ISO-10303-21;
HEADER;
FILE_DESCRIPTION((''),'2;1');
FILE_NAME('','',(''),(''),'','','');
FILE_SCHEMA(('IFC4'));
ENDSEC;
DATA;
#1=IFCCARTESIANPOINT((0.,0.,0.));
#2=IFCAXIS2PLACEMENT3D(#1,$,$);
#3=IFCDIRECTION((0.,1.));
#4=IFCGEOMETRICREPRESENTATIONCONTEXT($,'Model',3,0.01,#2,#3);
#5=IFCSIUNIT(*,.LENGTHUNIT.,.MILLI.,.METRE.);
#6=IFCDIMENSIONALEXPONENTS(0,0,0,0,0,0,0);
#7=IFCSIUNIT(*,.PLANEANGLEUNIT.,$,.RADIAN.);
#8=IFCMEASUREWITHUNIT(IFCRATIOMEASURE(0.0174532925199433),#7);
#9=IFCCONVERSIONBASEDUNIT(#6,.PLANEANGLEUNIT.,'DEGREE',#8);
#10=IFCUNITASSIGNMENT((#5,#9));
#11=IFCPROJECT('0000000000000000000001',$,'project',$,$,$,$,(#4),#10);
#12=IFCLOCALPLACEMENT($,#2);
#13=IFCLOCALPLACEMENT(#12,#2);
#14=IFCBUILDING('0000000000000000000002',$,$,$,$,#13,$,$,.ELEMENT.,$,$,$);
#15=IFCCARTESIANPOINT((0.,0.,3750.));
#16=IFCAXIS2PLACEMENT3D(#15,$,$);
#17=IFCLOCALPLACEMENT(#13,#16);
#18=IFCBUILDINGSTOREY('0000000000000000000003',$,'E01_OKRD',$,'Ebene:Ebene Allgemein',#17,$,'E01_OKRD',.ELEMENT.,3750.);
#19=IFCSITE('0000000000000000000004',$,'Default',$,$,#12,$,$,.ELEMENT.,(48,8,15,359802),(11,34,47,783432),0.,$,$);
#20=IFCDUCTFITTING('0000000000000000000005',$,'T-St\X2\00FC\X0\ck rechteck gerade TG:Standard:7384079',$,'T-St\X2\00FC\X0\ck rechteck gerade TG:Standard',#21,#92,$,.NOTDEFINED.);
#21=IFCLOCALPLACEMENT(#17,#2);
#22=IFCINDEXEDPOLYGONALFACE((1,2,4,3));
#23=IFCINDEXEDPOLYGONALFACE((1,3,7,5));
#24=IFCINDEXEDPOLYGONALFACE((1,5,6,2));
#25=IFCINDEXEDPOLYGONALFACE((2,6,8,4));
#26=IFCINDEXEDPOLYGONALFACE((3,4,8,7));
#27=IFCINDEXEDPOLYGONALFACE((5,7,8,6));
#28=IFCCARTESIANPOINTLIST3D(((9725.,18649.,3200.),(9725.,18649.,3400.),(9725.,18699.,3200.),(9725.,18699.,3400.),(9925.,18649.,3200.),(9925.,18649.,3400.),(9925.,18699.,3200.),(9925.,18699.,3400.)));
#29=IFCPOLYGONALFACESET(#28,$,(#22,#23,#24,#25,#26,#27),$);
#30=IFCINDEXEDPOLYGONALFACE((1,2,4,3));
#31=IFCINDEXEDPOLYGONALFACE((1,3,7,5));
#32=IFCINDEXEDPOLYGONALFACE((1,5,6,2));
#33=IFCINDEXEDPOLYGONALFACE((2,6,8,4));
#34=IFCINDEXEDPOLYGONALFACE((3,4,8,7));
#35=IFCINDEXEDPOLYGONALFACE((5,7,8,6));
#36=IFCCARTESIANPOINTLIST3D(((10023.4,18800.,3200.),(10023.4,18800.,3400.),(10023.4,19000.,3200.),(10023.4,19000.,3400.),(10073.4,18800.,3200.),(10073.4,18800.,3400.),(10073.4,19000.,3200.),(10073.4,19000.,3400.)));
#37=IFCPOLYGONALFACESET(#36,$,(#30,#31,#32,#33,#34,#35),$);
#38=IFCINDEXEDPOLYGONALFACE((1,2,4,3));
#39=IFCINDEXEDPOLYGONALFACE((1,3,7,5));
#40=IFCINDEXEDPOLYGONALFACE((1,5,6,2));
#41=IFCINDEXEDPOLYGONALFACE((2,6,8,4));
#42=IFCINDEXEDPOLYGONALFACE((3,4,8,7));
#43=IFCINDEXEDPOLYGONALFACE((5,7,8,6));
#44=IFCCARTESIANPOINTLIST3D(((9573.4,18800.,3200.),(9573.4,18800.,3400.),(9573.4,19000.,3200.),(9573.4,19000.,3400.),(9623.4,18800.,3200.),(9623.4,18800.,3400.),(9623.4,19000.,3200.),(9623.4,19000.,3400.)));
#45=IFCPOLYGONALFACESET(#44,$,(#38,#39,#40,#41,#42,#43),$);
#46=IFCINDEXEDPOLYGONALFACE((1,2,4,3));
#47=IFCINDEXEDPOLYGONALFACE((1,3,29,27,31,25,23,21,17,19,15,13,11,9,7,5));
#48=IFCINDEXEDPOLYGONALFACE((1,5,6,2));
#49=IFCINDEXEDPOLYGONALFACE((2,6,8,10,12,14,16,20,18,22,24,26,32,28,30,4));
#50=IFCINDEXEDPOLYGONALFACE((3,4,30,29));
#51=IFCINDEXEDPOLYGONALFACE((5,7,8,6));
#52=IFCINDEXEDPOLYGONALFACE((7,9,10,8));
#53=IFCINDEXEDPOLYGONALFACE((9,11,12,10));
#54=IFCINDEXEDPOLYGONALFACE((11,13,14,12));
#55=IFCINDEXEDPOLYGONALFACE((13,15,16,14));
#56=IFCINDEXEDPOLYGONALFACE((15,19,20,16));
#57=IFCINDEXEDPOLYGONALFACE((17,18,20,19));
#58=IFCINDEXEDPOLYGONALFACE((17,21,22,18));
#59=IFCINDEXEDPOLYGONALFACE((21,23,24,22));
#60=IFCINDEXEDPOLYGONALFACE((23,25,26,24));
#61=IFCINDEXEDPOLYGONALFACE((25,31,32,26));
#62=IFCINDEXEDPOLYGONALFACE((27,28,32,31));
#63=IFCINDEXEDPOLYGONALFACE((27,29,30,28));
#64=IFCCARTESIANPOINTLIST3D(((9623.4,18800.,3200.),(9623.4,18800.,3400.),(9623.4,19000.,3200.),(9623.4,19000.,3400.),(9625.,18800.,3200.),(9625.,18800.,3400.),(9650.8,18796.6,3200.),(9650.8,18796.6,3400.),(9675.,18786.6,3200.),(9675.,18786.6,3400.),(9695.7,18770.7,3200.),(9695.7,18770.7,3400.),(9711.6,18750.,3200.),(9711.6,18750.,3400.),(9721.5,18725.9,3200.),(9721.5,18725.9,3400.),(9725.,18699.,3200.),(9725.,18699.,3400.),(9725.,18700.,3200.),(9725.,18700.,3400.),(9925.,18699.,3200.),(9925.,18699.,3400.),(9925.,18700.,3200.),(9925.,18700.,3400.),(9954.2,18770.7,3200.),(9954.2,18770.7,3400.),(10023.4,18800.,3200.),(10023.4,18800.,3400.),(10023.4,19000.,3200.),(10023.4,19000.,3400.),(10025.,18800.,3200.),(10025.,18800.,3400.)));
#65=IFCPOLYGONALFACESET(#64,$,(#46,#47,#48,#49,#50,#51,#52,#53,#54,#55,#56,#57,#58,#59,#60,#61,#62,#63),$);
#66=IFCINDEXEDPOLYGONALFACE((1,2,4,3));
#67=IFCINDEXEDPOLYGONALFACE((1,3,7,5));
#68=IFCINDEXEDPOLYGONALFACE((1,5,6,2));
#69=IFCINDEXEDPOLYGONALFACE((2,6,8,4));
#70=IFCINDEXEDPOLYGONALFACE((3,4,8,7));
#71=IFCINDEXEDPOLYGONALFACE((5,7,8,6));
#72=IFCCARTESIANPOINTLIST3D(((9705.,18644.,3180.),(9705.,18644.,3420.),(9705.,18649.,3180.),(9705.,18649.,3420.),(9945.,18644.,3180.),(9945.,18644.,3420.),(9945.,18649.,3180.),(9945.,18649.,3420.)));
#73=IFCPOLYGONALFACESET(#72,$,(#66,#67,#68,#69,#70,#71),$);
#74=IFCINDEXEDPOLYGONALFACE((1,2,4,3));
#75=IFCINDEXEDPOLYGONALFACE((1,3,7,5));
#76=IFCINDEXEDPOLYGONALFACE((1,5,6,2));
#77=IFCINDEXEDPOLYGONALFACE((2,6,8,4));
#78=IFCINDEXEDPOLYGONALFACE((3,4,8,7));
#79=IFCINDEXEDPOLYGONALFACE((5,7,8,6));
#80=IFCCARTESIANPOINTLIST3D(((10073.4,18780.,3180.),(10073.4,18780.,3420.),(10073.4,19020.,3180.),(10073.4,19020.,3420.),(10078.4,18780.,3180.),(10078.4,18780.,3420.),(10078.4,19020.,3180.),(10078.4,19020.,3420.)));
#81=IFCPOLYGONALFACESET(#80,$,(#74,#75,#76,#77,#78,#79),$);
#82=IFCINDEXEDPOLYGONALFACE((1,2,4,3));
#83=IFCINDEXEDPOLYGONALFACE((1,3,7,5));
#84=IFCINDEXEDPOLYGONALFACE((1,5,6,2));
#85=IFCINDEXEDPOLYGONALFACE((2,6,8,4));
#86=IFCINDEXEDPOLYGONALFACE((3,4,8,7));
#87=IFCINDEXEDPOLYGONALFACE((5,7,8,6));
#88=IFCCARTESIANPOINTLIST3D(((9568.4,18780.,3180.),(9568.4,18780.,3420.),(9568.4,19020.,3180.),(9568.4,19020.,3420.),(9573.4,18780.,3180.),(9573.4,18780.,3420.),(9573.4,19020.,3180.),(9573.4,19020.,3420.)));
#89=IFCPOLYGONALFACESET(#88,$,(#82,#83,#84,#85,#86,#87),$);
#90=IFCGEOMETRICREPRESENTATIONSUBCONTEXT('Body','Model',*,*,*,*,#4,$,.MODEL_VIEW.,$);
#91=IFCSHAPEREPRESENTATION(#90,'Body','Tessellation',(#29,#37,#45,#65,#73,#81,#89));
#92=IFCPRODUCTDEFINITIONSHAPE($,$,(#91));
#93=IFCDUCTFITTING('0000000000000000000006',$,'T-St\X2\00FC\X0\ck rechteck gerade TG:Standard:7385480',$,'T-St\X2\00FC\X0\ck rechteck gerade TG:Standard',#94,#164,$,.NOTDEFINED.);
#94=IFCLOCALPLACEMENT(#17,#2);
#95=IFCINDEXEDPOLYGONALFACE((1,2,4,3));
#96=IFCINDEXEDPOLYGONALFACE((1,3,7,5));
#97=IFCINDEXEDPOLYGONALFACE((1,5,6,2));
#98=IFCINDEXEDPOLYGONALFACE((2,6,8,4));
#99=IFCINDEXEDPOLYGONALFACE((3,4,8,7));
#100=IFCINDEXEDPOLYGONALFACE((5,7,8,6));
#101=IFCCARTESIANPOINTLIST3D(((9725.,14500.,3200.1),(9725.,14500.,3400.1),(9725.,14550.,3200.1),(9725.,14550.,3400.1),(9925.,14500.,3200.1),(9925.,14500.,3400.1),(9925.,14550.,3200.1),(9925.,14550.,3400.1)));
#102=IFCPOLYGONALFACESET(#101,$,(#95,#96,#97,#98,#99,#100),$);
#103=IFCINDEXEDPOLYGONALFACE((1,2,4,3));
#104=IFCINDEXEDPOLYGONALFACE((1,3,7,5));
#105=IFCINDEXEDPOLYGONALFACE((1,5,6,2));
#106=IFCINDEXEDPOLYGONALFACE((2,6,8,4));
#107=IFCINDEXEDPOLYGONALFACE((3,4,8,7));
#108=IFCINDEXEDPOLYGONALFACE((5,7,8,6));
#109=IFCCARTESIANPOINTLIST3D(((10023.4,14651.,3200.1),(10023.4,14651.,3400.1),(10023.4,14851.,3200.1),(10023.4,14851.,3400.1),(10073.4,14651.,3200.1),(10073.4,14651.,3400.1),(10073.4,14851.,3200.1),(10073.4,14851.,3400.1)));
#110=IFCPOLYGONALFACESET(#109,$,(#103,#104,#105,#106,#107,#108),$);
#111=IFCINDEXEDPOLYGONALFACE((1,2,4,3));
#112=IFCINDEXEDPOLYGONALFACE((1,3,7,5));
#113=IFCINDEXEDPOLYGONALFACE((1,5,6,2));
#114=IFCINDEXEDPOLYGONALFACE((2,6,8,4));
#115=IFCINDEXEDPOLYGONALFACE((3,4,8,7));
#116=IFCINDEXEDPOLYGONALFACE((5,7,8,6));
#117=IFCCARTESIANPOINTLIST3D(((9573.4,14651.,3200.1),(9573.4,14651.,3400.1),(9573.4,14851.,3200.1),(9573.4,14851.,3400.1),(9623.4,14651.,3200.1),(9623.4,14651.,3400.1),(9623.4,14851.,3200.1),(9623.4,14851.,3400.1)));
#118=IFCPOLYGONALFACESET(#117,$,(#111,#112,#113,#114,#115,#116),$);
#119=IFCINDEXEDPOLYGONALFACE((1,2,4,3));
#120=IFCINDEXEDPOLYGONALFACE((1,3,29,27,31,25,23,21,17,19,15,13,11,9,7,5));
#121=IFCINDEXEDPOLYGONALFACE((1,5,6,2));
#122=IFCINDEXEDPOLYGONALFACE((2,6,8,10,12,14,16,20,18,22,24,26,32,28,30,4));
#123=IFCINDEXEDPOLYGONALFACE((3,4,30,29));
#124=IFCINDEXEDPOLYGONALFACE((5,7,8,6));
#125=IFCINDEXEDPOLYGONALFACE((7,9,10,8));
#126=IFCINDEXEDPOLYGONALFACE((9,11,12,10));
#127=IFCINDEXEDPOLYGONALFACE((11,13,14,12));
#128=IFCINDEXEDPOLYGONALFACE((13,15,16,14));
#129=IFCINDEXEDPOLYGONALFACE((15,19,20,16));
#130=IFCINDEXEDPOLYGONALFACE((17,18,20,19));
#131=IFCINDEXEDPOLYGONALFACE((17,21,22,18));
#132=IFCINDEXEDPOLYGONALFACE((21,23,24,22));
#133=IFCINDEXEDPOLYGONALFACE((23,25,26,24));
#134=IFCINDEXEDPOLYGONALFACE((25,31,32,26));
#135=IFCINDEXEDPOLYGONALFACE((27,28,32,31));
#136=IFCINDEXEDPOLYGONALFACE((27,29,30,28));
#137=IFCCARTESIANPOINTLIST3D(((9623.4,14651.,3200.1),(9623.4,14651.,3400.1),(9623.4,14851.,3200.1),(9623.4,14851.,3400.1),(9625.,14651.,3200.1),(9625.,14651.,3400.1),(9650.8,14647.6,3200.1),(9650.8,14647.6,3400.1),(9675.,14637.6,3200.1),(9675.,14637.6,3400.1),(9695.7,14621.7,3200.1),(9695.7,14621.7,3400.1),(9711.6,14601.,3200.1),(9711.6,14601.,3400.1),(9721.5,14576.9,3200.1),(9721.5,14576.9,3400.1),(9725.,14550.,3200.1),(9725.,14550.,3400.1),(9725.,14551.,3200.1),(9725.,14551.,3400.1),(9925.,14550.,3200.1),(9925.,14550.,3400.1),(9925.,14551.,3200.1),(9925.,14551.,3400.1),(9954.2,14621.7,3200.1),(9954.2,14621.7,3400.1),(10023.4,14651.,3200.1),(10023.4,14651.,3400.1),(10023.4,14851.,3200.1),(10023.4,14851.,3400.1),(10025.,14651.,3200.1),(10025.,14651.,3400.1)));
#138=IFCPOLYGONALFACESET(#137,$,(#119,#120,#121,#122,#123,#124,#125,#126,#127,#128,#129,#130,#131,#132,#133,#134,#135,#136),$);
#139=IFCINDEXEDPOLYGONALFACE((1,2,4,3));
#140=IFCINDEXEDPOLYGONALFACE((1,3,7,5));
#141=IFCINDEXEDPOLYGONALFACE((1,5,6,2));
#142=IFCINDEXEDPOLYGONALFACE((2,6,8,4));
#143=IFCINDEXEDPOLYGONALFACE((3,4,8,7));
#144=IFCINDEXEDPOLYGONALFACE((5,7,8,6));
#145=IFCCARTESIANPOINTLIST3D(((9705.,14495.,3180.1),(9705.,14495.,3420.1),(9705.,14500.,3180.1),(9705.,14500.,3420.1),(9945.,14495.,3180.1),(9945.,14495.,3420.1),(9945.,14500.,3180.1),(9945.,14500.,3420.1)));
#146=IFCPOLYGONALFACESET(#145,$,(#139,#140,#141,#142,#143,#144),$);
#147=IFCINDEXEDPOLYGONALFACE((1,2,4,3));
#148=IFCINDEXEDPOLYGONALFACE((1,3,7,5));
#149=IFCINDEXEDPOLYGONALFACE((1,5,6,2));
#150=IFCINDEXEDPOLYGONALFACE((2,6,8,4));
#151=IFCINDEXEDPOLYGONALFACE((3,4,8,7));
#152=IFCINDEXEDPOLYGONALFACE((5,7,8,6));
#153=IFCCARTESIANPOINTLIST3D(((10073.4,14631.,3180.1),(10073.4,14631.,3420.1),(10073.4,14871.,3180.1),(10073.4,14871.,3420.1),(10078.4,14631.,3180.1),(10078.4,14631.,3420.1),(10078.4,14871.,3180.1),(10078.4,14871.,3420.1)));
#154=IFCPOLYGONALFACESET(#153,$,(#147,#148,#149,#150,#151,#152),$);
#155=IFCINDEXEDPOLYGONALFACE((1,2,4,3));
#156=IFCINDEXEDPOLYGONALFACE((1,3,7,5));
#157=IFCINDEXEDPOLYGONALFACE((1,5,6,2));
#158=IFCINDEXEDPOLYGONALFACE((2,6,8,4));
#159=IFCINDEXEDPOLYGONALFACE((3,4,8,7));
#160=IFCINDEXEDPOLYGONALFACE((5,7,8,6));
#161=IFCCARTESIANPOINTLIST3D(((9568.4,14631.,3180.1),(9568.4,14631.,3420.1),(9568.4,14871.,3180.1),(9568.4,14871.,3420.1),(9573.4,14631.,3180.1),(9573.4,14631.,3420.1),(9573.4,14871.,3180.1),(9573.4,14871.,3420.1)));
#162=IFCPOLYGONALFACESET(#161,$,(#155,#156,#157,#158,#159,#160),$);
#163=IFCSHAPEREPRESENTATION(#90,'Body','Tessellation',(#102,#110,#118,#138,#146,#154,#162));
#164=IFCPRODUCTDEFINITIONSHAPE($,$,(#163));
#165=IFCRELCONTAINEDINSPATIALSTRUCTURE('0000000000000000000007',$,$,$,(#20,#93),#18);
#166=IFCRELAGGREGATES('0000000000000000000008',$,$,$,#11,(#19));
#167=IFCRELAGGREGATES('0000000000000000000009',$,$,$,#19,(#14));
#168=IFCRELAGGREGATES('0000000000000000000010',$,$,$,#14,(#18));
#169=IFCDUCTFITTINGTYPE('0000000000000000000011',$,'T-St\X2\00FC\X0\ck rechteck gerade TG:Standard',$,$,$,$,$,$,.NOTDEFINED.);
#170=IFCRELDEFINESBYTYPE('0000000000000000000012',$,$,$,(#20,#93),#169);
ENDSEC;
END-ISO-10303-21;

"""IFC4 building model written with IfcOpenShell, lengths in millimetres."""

from ifc_helpers import new_model, entity, si_unit, converted_unit, direction, frame, frame_2d, origin, origin_2d_with_axis, place, context, subcontext, project, spatial, polyline, circle_curve, parameter, trimmed, segment, composite_curve, rectangle, outline, extrude, source, transform, mapped, type_object, type_shapes, element, save


model = new_model("IFC4")

# Units and contexts
model_context = context("Model", 3, precision=0.01, world=origin(), true_north=direction((0.0, 1.0)))
body_context = subcontext(model_context, "Body", "Model", "MODEL_VIEW")
ifc_project = project(units=[si_unit("LENGTHUNIT", "METRE", prefix="MILLI"), converted_unit("PLANEANGLEUNIT", "DEGREE", entity("IfcRatioMeasure", 0.0174532925199433), si_unit("PLANEANGLEUNIT", "RADIAN"), dimensions=[0, 0, 0, 0, 0, 0, 0])], contexts=[model_context])

# Site, building, storey
site_placement = place(None, origin())
site = spatial("IfcSite", under=ifc_project, at=site_placement, Name="Default", CompositionType="ELEMENT", RefLatitude=(48, 8, 15, 359802), RefLongitude=(11, 34, 47, 783432), RefElevation=0.0)
building_placement = place(site_placement, origin())
building = spatial("IfcBuilding", under=site, at=building_placement, CompositionType="ELEMENT")
storey_placement = place(building_placement, frame((0.0, 0.0, 3750.0)))
storey = spatial("IfcBuildingStorey", under=building, at=storey_placement, Name="E01_OKRD", ObjectType="Ebene:Ebene Allgemein", LongName="E01_OKRD", CompositionType="ELEMENT", Elevation=3750.0)

# Duct fittings
duct_fitting_type_1 = type_object("IfcDuctFittingType", Name="T-Stück rechteck gerade TG:Standard", PredefinedType="NOTDEFINED")
shared_shape_1 = source(origin(), body_context, "Body", "SweptSolid", [
    extrude(rectangle(XDim=50.0, YDim=200.0, at=frame_2d((0.0, 0.0), x_axis=(1.0, 0.0))), frame((0.0, -226.0, -100.0), z_axis=(0.0, 0.0, 1.0), x_axis=(0.0, -1.0, 0.0)), (0.0, 0.0, 1.0), 200.0),
    extrude(rectangle(XDim=50.0, YDim=200.0, at=frame_2d((0.0, 0.0), x_axis=(1.0, 0.0))), frame((223.4, 0.0, -100.0), z_axis=(0.0, 0.0, 1.0), x_axis=(-1.0, 0.0, 0.0)), (0.0, 0.0, 1.0), 200.0),
    extrude(rectangle(XDim=50.0, YDim=200.0, at=frame_2d((0.0, 0.0), x_axis=(1.0, 0.0))), frame((-226.6, 0.0, -100.0)), (0.0, 0.0, 1.0), 200.0),
    extrude(outline(composite_curve([segment(trimmed(circle_curve(frame_2d((-200.6, -99.8), x_axis=(-1.0, 0.0)), 100.0), [parameter(180.0)], [parameter(270.0)], True, "PARAMETER"), False, "CONTINUOUS"), segment(polyline([(-100.6, -99.8), (-100.6, -100.8)]), True, "CONTINUOUS"), segment(polyline([(-100.6, -100.8), (99.4, -100.8)]), True, "CONTINUOUS"), segment(polyline([(99.4, -100.8), (99.4, -99.8)]), True, "CONTINUOUS"), segment(trimmed(circle_curve(frame_2d((199.4, -99.8), x_axis=(-1.0, 0.0)), 100.0), [parameter(270.0)], [parameter(0.0)], True, "PARAMETER"), False, "CONTINUOUS"), segment(polyline([(199.4, 0.2), (201.0, 0.2)]), True, "CONTINUOUS"), segment(polyline([(201.0, 0.2), (201.0, 200.2)]), True, "CONTINUOUS"), segment(polyline([(201.0, 200.2), (-199.0, 200.2)]), True, "CONTINUOUS"), segment(polyline([(-199.0, 200.2), (-199.0, 0.2)]), True, "CONTINUOUS"), segment(polyline([(-199.0, 0.2), (-200.6, 0.2)]), True, "CONTINUOUS")], self_intersect=False)), frame((-0.6, -100.2, -100.0), z_axis=(0.0, 0.0, -1.0), x_axis=(-1.0, 0.0, 0.0)), (0.0, 0.0, -1.0), 200.0),
    extrude(rectangle(XDim=5.0, YDim=240.0, at=frame_2d((0.0, 0.0), x_axis=(1.0, 0.0))), frame((0.0, -253.5, -120.0), z_axis=(0.0, 0.0, 1.0), x_axis=(0.0, 1.0, 0.0)), (0.0, 0.0, 1.0), 240.0),
    extrude(rectangle(XDim=5.0, YDim=240.0, at=origin_2d_with_axis()), frame((250.9, 0.0, -120.0), z_axis=(0.0, 0.0, 1.0), x_axis=(-1.0, 0.0, 0.0)), (0.0, 0.0, 1.0), 240.0),
    extrude(rectangle(XDim=5.0, YDim=240.0, at=origin_2d_with_axis()), frame((-254.1, 0.0, -120.0), z_axis=(0.0, 0.0, 1.0), x_axis=(-1.0, 0.0, 0.0)), (0.0, 0.0, 1.0), 240.0),
])
type_shapes(duct_fitting_type_1, [shared_shape_1])
for number, where, name in (
    (1, (9825.0, 18900.0, 3300.0), "T-Stück rechteck gerade TG:Standard:7384079"),
    (2, (9825.0, 14751.0, 3300.1), "T-Stück rechteck gerade TG:Standard:7385480"),
):
    element("IfcDuctFitting", number, at=place(storey_placement, frame(where)), inside=storey, type_object=duct_fitting_type_1, Name=name, ObjectType="T-Stück rechteck gerade TG:Standard", PredefinedType="NOTDEFINED", context=body_context, shape_type="MappedRepresentation", body=[
        mapped(shared_shape_1, transform((0.0, 0.0, 0.0), scale=1.0)),
    ])

save(model, "model.ifc")
